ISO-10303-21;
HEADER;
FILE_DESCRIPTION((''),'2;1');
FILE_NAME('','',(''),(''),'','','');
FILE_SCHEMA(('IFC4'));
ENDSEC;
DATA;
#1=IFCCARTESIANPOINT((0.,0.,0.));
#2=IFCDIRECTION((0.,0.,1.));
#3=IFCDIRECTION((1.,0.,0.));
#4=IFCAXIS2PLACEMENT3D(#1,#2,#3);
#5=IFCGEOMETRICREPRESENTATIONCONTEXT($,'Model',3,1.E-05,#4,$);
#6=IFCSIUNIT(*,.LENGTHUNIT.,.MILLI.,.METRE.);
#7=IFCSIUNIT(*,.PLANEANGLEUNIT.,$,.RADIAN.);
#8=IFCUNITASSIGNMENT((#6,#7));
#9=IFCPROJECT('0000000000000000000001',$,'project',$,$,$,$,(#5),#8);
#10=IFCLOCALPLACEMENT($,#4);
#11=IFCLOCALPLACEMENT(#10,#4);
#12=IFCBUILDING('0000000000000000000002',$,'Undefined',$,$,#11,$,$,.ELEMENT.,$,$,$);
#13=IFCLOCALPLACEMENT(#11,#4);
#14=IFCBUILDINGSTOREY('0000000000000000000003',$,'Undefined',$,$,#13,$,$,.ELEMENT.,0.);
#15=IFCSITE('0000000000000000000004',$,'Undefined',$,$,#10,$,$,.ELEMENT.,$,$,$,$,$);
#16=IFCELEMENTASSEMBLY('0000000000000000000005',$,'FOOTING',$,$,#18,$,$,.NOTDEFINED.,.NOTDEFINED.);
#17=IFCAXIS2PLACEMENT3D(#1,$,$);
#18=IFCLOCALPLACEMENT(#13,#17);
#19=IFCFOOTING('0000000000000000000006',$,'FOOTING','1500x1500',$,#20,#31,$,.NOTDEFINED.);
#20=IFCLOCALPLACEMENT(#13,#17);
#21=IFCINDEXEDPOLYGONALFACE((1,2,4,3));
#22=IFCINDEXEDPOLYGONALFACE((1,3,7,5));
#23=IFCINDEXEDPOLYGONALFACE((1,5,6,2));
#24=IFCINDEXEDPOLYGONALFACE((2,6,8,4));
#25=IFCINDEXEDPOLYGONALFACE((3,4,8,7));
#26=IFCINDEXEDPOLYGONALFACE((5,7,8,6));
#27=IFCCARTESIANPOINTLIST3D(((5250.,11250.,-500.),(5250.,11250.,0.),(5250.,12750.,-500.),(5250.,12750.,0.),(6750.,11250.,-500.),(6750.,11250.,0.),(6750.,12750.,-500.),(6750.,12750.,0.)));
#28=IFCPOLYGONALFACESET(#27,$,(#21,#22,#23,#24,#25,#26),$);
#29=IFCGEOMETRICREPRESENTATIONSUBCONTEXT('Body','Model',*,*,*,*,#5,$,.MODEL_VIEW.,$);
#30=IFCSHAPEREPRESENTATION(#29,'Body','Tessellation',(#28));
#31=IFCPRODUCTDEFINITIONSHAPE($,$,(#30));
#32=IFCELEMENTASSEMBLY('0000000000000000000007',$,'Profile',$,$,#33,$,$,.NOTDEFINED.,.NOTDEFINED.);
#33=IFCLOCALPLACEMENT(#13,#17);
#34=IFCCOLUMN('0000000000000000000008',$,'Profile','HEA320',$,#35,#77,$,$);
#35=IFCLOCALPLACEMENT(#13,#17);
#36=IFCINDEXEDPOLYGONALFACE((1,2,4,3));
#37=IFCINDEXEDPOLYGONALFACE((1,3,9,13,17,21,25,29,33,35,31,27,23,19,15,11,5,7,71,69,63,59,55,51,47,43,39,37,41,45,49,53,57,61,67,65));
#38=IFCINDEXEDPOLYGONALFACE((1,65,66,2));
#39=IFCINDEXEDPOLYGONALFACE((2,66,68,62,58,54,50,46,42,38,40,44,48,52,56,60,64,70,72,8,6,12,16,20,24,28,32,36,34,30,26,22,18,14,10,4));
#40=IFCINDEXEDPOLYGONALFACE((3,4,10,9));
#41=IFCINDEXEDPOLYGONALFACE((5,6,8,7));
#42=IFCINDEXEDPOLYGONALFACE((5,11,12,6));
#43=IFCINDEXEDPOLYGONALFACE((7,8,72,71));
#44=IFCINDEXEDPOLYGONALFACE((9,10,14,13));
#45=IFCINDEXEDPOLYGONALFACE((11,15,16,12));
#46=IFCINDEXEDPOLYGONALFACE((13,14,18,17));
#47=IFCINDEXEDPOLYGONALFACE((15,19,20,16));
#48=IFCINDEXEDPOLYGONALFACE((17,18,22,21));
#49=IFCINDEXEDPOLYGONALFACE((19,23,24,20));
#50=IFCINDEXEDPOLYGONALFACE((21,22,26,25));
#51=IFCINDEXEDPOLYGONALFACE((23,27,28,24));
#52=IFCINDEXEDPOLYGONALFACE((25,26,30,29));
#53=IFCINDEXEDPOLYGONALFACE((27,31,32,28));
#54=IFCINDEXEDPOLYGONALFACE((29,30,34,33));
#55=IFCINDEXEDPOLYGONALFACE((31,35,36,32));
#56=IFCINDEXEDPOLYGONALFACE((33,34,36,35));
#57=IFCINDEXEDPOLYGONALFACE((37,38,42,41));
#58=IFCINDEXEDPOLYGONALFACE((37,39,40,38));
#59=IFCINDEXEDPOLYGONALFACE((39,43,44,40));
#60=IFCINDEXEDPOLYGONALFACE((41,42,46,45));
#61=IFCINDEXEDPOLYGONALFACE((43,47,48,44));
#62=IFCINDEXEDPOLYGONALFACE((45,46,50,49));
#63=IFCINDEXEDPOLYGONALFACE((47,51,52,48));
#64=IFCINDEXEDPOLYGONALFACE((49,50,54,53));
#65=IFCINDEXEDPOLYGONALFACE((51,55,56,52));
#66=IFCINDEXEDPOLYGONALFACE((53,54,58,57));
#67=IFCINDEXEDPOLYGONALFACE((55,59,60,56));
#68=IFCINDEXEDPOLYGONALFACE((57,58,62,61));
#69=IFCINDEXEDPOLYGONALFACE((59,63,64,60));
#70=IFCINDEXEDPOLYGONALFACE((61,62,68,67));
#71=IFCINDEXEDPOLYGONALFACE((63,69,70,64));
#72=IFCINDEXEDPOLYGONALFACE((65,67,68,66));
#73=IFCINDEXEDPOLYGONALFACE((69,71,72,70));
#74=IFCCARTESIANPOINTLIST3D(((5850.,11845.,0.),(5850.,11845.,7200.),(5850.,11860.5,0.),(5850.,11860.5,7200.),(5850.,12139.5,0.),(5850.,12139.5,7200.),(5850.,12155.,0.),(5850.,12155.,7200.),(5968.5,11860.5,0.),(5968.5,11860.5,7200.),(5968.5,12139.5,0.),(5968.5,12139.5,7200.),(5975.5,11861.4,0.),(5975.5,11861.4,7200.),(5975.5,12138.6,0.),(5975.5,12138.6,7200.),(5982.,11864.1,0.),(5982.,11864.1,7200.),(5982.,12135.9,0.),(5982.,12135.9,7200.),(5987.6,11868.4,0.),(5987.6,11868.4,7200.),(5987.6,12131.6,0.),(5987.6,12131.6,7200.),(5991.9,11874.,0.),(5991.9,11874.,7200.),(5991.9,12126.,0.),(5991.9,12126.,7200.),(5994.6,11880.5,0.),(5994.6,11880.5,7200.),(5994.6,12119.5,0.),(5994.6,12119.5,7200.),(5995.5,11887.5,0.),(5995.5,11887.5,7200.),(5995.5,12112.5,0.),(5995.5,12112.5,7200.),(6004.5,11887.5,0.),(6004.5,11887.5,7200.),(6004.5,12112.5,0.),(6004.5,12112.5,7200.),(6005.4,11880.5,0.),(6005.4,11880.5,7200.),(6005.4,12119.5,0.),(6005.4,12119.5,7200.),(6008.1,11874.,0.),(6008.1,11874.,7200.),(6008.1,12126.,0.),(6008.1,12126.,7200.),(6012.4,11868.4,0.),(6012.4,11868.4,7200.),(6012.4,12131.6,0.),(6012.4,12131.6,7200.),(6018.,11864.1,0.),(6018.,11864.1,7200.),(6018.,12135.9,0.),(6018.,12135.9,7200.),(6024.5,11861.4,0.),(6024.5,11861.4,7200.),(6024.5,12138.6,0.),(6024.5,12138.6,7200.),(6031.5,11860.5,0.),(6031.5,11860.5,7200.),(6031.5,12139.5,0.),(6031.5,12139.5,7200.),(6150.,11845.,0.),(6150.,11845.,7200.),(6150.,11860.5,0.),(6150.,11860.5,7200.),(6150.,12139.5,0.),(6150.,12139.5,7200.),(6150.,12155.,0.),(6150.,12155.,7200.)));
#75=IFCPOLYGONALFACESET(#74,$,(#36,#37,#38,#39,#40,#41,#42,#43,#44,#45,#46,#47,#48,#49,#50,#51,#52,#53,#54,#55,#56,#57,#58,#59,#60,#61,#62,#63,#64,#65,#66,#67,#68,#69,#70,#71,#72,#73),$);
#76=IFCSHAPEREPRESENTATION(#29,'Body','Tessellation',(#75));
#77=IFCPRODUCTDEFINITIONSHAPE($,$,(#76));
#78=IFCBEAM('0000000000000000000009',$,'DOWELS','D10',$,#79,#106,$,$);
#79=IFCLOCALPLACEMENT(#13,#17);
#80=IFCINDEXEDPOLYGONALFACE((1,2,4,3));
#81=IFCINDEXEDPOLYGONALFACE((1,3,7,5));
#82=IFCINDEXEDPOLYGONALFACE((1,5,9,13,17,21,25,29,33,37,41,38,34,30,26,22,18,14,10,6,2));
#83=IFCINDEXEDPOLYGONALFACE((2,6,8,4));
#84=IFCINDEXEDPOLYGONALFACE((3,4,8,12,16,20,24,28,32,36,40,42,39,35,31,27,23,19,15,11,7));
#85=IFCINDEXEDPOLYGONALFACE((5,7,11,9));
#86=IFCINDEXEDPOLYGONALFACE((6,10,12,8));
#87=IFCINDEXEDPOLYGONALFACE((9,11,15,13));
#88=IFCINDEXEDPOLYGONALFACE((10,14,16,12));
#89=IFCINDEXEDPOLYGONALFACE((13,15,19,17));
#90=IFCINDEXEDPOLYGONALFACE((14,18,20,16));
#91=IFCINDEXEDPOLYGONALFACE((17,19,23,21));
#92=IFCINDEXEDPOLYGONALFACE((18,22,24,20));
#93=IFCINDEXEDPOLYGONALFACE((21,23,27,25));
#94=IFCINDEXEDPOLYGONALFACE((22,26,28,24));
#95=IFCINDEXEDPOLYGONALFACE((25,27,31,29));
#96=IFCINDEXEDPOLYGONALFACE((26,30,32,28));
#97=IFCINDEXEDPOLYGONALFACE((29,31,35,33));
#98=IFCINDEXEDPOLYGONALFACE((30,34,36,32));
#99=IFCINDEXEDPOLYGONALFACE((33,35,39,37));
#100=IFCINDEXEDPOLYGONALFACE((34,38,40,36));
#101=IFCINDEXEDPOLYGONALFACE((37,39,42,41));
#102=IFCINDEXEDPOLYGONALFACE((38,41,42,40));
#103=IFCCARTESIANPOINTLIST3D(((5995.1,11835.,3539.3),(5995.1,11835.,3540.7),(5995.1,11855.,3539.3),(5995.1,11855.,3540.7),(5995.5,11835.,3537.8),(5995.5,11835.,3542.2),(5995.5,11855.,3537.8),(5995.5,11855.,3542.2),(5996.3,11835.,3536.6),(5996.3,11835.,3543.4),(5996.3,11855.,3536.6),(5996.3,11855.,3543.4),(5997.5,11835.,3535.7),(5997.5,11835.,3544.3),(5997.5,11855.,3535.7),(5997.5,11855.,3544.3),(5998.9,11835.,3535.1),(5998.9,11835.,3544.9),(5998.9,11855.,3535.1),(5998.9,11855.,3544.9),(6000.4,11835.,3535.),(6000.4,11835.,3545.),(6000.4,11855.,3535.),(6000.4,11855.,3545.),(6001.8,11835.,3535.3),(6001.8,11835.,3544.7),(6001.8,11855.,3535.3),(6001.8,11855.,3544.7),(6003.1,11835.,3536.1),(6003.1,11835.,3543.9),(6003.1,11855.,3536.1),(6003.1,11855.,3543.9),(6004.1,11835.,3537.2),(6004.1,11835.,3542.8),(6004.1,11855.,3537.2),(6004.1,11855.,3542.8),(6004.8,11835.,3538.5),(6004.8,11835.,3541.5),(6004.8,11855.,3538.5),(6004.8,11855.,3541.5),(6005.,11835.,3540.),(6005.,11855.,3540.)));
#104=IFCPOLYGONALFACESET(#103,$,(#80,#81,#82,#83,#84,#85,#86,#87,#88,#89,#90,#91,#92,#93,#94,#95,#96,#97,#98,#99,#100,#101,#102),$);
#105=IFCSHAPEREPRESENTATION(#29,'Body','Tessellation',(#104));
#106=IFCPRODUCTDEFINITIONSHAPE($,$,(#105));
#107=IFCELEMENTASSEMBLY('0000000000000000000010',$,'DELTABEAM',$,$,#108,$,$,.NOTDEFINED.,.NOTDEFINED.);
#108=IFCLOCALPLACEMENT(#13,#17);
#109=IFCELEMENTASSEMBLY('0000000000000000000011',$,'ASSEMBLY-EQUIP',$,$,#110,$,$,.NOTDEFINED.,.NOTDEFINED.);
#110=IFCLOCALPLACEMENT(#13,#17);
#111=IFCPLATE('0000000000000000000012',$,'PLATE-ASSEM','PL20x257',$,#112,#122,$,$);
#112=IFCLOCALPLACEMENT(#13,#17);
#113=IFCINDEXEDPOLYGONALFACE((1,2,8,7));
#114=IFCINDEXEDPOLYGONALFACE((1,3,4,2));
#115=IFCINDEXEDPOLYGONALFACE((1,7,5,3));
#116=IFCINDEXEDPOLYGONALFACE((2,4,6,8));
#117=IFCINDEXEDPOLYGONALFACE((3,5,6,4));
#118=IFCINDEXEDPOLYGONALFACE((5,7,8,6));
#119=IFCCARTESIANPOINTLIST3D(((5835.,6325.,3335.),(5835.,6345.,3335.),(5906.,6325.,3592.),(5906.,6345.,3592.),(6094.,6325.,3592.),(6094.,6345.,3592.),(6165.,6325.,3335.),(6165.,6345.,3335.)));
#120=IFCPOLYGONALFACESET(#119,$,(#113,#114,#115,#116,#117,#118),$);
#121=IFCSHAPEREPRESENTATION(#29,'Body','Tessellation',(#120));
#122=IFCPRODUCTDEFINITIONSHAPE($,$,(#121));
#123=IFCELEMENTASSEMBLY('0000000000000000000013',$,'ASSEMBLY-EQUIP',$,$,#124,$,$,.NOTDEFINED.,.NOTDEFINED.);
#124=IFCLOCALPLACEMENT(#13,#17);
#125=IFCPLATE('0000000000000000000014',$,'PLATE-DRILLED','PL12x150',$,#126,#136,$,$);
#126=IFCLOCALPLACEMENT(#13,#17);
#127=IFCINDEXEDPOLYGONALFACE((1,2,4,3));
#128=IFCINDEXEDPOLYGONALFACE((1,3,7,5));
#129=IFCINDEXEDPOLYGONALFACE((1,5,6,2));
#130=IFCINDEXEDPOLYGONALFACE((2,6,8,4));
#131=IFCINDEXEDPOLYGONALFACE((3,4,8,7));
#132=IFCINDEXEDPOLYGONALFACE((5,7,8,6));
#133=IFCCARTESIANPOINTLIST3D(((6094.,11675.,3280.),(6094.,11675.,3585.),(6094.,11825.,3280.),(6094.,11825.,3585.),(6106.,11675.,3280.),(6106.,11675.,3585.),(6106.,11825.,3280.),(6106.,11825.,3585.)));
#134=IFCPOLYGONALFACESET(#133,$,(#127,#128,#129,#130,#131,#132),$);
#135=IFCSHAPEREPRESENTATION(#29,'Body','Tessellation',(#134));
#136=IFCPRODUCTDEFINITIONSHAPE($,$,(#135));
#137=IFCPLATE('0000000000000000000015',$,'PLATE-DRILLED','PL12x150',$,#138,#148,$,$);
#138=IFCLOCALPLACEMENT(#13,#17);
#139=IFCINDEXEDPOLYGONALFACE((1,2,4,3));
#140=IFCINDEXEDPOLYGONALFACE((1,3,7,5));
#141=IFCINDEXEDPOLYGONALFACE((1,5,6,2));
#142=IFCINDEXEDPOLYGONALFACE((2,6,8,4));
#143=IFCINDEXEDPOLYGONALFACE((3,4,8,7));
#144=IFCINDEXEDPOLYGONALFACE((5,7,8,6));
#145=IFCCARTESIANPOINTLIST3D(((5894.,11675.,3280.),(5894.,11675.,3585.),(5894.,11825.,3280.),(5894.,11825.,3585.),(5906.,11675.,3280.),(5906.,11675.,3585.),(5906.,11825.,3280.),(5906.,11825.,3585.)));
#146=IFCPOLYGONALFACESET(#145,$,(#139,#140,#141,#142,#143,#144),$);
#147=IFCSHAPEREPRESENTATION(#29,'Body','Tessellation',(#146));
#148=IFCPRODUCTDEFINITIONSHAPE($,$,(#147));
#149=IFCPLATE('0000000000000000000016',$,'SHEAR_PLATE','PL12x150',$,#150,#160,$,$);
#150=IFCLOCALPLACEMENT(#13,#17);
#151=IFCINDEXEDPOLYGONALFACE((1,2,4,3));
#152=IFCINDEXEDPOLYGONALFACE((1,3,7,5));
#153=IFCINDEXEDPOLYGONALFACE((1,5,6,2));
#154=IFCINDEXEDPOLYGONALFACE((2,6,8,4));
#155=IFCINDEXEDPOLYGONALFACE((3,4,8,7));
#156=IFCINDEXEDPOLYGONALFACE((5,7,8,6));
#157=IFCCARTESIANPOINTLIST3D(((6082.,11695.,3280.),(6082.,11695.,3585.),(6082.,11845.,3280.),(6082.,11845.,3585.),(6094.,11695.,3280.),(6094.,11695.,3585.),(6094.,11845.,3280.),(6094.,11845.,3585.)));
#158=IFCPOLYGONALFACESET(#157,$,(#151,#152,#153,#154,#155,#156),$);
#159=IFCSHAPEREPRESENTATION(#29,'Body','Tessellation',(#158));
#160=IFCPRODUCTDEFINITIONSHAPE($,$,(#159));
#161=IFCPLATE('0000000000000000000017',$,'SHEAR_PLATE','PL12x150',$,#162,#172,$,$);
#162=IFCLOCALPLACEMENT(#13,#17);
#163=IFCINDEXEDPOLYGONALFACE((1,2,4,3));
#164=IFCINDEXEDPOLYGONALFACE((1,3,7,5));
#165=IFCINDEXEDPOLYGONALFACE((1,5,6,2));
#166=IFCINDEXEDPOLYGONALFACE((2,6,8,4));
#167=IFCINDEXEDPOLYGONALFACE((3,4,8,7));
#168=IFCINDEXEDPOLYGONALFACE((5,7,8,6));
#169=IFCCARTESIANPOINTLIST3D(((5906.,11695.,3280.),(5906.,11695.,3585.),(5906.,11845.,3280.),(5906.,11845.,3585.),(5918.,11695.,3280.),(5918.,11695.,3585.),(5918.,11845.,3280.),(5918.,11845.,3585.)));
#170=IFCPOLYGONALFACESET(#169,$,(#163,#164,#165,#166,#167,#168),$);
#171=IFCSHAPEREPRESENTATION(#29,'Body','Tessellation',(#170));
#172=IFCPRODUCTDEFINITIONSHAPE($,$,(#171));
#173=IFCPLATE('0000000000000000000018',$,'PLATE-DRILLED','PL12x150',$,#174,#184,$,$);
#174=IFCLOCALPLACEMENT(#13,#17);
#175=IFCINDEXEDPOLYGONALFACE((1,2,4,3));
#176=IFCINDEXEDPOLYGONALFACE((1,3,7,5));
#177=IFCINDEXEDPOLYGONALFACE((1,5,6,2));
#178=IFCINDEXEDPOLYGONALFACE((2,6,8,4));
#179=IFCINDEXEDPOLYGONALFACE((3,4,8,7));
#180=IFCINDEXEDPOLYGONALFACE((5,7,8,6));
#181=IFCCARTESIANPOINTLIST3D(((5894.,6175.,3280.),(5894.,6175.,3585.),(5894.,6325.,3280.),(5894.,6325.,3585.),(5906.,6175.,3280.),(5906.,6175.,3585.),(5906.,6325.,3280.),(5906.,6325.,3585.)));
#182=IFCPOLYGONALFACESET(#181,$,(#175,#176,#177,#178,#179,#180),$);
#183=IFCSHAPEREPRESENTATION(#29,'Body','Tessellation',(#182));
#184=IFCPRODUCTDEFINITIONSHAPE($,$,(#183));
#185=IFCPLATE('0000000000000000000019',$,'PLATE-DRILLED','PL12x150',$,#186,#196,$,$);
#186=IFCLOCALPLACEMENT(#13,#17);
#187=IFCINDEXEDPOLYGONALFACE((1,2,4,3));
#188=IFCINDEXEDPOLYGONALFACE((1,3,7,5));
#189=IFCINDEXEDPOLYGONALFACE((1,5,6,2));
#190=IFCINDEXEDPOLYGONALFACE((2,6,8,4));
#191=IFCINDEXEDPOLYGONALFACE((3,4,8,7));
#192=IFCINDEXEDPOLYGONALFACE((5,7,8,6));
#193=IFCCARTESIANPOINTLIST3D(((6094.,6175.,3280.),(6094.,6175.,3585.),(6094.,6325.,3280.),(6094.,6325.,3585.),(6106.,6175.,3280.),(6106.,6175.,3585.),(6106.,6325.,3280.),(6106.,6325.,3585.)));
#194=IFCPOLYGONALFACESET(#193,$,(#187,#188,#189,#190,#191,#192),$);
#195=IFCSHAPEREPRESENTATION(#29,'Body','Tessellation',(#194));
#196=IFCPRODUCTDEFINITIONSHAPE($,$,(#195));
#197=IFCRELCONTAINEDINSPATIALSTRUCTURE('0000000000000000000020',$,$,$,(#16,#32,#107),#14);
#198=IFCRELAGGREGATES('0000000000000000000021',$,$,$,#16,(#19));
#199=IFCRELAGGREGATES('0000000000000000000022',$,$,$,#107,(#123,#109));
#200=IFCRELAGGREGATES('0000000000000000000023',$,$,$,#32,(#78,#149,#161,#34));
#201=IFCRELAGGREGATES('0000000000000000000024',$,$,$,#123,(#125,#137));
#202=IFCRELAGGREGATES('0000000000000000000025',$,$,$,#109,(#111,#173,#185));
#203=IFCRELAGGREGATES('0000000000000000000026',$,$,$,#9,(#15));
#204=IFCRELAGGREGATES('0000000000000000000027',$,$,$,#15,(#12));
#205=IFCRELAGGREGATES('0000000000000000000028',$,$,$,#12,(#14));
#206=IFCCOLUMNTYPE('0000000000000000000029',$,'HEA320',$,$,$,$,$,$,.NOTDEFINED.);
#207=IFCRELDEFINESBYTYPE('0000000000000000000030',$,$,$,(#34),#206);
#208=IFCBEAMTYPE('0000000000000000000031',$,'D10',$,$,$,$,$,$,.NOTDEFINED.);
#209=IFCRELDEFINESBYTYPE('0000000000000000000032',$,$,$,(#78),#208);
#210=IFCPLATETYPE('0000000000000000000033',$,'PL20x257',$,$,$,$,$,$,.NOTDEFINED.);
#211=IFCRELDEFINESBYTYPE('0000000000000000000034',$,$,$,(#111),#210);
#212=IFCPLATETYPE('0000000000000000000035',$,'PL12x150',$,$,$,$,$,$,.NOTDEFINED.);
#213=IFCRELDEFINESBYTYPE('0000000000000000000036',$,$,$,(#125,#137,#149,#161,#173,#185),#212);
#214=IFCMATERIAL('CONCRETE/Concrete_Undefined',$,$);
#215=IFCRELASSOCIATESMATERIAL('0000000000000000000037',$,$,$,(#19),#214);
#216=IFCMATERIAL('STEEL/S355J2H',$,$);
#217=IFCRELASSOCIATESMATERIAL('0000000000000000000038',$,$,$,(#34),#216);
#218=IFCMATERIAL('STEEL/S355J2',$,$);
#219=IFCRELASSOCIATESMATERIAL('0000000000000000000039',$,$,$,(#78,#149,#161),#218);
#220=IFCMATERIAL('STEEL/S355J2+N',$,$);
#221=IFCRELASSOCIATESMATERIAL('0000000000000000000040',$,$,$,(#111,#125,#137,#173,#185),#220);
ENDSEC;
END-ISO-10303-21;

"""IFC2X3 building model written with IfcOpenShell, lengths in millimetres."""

from ifc_helpers import new_model, si_unit, frame, origin_with_axes, origin_2d_with_axis, place, context, subcontext, project, spatial, polyline, rectangle, circle, i_section, outline, extrude, material, type_object, element, aggregate, save


model = new_model("IFC2X3")

# Units and contexts
model_context = context("Model", 3, precision=1e-05, world=origin_with_axes())
body_context = subcontext(model_context, "Body", "Model", "MODEL_VIEW")
ifc_project = project(units=[si_unit("LENGTHUNIT", "METRE", prefix="MILLI"), si_unit("PLANEANGLEUNIT", "RADIAN")], contexts=[model_context])

# Site, building, storey
site_placement = place(None, origin_with_axes())
site = spatial("IfcSite", under=ifc_project, at=site_placement, Name="Undefined", CompositionType="ELEMENT")
building_placement = place(site_placement, origin_with_axes())
building = spatial("IfcBuilding", under=site, at=building_placement, Name="Undefined", CompositionType="ELEMENT")
storey_placement = place(building_placement, origin_with_axes())
storey = spatial("IfcBuildingStorey", under=building, at=storey_placement, Name="Undefined", CompositionType="ELEMENT", Elevation=0.0)

# Element assembly, footing
assembly_1_placement = place(storey_placement, origin_with_axes())
assembly_1 = element("IfcElementAssembly", 1, at=assembly_1_placement, inside=storey, Name="FOOTING", AssemblyPlace="NOTDEFINED", PredefinedType="NOTDEFINED")
ifc_material_1 = material(Name="CONCRETE/Concrete_Undefined")
footing_placement = place(assembly_1_placement, frame((6000.0, 12000.0, -500.0), z_axis=(0.0, 1.0, 0.0), x_axis=(0.0, 0.0, 1.0)))
footing = element("IfcFooting", 2, at=footing_placement, material=ifc_material_1, Name="FOOTING", Description="1500x1500", PredefinedType="NOTDEFINED", context=body_context, shape_type="SweptSolid", body=[
    extrude(rectangle(XDim=1500.0, YDim=1500.0, at=origin_2d_with_axis()), frame((500.0, 0.0, 0.0), z_axis=(-1.0, 0.0, 0.0), x_axis=(0.0, -1.0, 0.0)), (0.0, 0.0, 1.0), 500.0),
])
aggregate(assembly_1, [footing])

# Element assembly, column, beam
assembly_2_placement = place(storey_placement, origin_with_axes())
assembly_2 = element("IfcElementAssembly", 3, at=assembly_2_placement, inside=storey, Name="Profile", AssemblyPlace="NOTDEFINED", PredefinedType="NOTDEFINED")
ifc_material_2 = material(Name="STEEL/S355J2H")
column_type = type_object("IfcColumnType", Name="HEA320", PredefinedType="NOTDEFINED")
column_placement = place(assembly_2_placement, frame((6000.0, 12000.0, 0.0), z_axis=(0.0, 0.0, 1.0), x_axis=(0.0, 1.0, 0.0)))
column = element("IfcColumn", 4, at=column_placement, type_object=column_type, material=ifc_material_2, Name="Profile", Description="HEA320", context=body_context, shape_type="SweptSolid", body=[
    extrude(i_section(OverallWidth=300.0, OverallDepth=310.0, WebThickness=9.0, FlangeThickness=15.5, FilletRadius=27.0, at=origin_2d_with_axis()), frame((0.0, 0.0, 7200.0), z_axis=(0.0, 0.0, -1.0), x_axis=(0.0, 1.0, 0.0)), (0.0, 0.0, 1.0), 7200.0),
])
ifc_material_3 = material(Name="STEEL/S355J2")
beam_type_1 = type_object("IfcBeamType", Name="D10", PredefinedType="NOTDEFINED")
beam_1_placement = place(assembly_2_placement, frame((6000.0, 11835.0, 3540.0), z_axis=(0.0, 0.0, 1.0), x_axis=(0.0, 1.0, 0.0)))
beam_1 = element("IfcBeam", 5, at=beam_1_placement, type_object=beam_type_1, material=ifc_material_3, Name="DOWELS", Description="D10", context=body_context, shape_type="SweptSolid", body=[
    extrude(circle(Radius=5.0, at=origin_2d_with_axis()), frame((20.0, 0.0, 0.0), z_axis=(-1.0, 0.0, 0.0), x_axis=(0.0, -1.0, 0.0)), (0.0, 0.0, 1.0), 20.0),
])

# Element assemblies, plates
assembly_3_placement = place(storey_placement, origin_with_axes())
assembly_3 = element("IfcElementAssembly", 6, at=assembly_3_placement, inside=storey, Name="DELTABEAM", AssemblyPlace="NOTDEFINED", PredefinedType="NOTDEFINED")
assembly_4_placement = place(assembly_3_placement, origin_with_axes())
assembly_4 = element("IfcElementAssembly", 7, at=assembly_4_placement, Name="ASSEMBLY-EQUIP", AssemblyPlace="NOTDEFINED", PredefinedType="NOTDEFINED")
ifc_material_4 = material(Name="STEEL/S355J2+N")
plate_type_1 = type_object("IfcPlateType", Name="PL20x257", PredefinedType="NOTDEFINED")
plate_1_placement = place(assembly_4_placement, frame((6165.0, 6335.0, 3335.0), z_axis=(0.0, 1.0, 0.0), x_axis=(-1.0, 0.0, 0.0)))
plate_1 = element("IfcPlate", 8, at=plate_1_placement, type_object=plate_type_1, material=ifc_material_4, Name="PLATE-ASSEM", Description="PL20x257", context=body_context, shape_type="SweptSolid", body=[
    extrude(outline(polyline([(0.0, 0.0), (330.0, 0.0), (259.0, 257.0), (71.0, 257.0), (0.0, 0.0)])), frame((0.0, 0.0, -10.0), z_axis=(0.0, 0.0, 1.0), x_axis=(1.0, 0.0, 0.0)), (0.0, 0.0, 1.0), 20.0),
])
assembly_5_placement = place(assembly_3_placement, origin_with_axes())
assembly_5 = element("IfcElementAssembly", 9, at=assembly_5_placement, Name="ASSEMBLY-EQUIP", AssemblyPlace="NOTDEFINED", PredefinedType="NOTDEFINED")
aggregate(assembly_3, [assembly_5, assembly_4])
plate_type_2 = type_object("IfcPlateType", Name="PL12x150", PredefinedType="NOTDEFINED")
plate_2_placement = place(assembly_5_placement, frame((6100.0, 11675.0, 3585.0), z_axis=(-1.0, 0.0, 0.0), x_axis=(0.0, 1.0, 0.0)))
plate_2 = element("IfcPlate", 10, at=plate_2_placement, type_object=plate_type_2, material=ifc_material_4, Name="PLATE-DRILLED", Description="PL12x150", context=body_context, shape_type="SweptSolid", body=[
    extrude(outline(polyline([(0.0, 0.0), (150.0, 0.0), (150.0, 0.0), (150.0, 305.0), (150.0, 305.0), (0.0, 305.0), (0.0, 305.0), (0.0, 0.0)])), frame((0.0, 0.0, -6.0), z_axis=(0.0, 0.0, 1.0), x_axis=(1.0, 0.0, 0.0)), (0.0, 0.0, 1.0), 12.0),
])
plate_3_placement = place(assembly_5_placement, frame((5900.0, 11675.0, 3585.0), z_axis=(-1.0, 0.0, 0.0), x_axis=(0.0, 1.0, 0.0)))
plate_3 = element("IfcPlate", 11, at=plate_3_placement, type_object=plate_type_2, material=ifc_material_4, Name="PLATE-DRILLED", Description="PL12x150", context=body_context, shape_type="SweptSolid", body=[
    extrude(outline(polyline([(0.0, 0.0), (150.0, 0.0), (150.0, 0.0), (150.0, 305.0), (150.0, 305.0), (0.0, 305.0), (0.0, 305.0), (0.0, 0.0)])), frame((0.0, 0.0, -6.0), z_axis=(0.0, 0.0, 1.0), x_axis=(1.0, 0.0, 0.0)), (0.0, 0.0, 1.0), 12.0),
])

# Plates
plate_4_placement = place(assembly_2_placement, frame((6088.0, 11845.0, 3585.0), z_axis=(1.0, 0.0, 0.0), x_axis=(0.0, -1.0, 0.0)))
plate_4 = element("IfcPlate", 12, at=plate_4_placement, type_object=plate_type_2, material=ifc_material_3, Name="SHEAR_PLATE", Description="PL12x150", context=body_context, shape_type="SweptSolid", body=[
    extrude(outline(polyline([(0.0, 0.0), (150.0, 0.0), (150.0, 0.0), (150.0, 305.0), (150.0, 305.0), (0.0, 305.0), (0.0, 305.0), (0.0, 0.0)])), frame((0.0, 0.0, -6.0), z_axis=(0.0, 0.0, 1.0), x_axis=(1.0, 0.0, 0.0)), (0.0, 0.0, 1.0), 12.0),
])
plate_5_placement = place(assembly_2_placement, frame((5912.0, 11845.0, 3585.0), z_axis=(1.0, 0.0, 0.0), x_axis=(0.0, -1.0, 0.0)))
plate_5 = element("IfcPlate", 13, at=plate_5_placement, type_object=plate_type_2, material=ifc_material_3, Name="SHEAR_PLATE", Description="PL12x150", context=body_context, shape_type="SweptSolid", body=[
    extrude(outline(polyline([(0.0, 0.0), (150.0, 0.0), (150.0, 0.0), (150.0, 305.0), (150.0, 305.0), (0.0, 305.0), (0.0, 305.0), (0.0, 0.0)])), frame((0.0, 0.0, -6.0), z_axis=(0.0, 0.0, 1.0), x_axis=(1.0, 0.0, 0.0)), (0.0, 0.0, 1.0), 12.0),
])
aggregate(assembly_2, [beam_1, plate_4, plate_5, column])
plate_6_placement = place(assembly_4_placement, frame((5900.0, 6325.0, 3585.0), z_axis=(1.0, 0.0, 0.0), x_axis=(0.0, -1.0, 0.0)))
plate_6 = element("IfcPlate", 14, at=plate_6_placement, type_object=plate_type_2, material=ifc_material_4, Name="PLATE-DRILLED", Description="PL12x150", context=body_context, shape_type="SweptSolid", body=[
    extrude(outline(polyline([(0.0, 0.0), (150.0, 0.0), (150.0, 0.0), (150.0, 305.0), (150.0, 305.0), (0.0, 305.0), (0.0, 305.0), (0.0, 0.0)])), frame((0.0, 0.0, -6.0), z_axis=(0.0, 0.0, 1.0), x_axis=(1.0, 0.0, 0.0)), (0.0, 0.0, 1.0), 12.0),
])
plate_7_placement = place(assembly_4_placement, frame((6100.0, 6325.0, 3585.0), z_axis=(1.0, 0.0, 0.0), x_axis=(0.0, -1.0, 0.0)))
plate_7 = element("IfcPlate", 15, at=plate_7_placement, type_object=plate_type_2, material=ifc_material_4, Name="PLATE-DRILLED", Description="PL12x150", context=body_context, shape_type="SweptSolid", body=[
    extrude(outline(polyline([(0.0, 0.0), (150.0, 0.0), (150.0, 0.0), (150.0, 305.0), (150.0, 305.0), (0.0, 305.0), (0.0, 305.0), (0.0, 0.0)])), frame((0.0, 0.0, -6.0), z_axis=(0.0, 0.0, 1.0), x_axis=(1.0, 0.0, 0.0)), (0.0, 0.0, 1.0), 12.0),
])

aggregate(assembly_5, [plate_2, plate_3])
aggregate(assembly_4, [plate_1, plate_6, plate_7])

save(model, "model.ifc")
